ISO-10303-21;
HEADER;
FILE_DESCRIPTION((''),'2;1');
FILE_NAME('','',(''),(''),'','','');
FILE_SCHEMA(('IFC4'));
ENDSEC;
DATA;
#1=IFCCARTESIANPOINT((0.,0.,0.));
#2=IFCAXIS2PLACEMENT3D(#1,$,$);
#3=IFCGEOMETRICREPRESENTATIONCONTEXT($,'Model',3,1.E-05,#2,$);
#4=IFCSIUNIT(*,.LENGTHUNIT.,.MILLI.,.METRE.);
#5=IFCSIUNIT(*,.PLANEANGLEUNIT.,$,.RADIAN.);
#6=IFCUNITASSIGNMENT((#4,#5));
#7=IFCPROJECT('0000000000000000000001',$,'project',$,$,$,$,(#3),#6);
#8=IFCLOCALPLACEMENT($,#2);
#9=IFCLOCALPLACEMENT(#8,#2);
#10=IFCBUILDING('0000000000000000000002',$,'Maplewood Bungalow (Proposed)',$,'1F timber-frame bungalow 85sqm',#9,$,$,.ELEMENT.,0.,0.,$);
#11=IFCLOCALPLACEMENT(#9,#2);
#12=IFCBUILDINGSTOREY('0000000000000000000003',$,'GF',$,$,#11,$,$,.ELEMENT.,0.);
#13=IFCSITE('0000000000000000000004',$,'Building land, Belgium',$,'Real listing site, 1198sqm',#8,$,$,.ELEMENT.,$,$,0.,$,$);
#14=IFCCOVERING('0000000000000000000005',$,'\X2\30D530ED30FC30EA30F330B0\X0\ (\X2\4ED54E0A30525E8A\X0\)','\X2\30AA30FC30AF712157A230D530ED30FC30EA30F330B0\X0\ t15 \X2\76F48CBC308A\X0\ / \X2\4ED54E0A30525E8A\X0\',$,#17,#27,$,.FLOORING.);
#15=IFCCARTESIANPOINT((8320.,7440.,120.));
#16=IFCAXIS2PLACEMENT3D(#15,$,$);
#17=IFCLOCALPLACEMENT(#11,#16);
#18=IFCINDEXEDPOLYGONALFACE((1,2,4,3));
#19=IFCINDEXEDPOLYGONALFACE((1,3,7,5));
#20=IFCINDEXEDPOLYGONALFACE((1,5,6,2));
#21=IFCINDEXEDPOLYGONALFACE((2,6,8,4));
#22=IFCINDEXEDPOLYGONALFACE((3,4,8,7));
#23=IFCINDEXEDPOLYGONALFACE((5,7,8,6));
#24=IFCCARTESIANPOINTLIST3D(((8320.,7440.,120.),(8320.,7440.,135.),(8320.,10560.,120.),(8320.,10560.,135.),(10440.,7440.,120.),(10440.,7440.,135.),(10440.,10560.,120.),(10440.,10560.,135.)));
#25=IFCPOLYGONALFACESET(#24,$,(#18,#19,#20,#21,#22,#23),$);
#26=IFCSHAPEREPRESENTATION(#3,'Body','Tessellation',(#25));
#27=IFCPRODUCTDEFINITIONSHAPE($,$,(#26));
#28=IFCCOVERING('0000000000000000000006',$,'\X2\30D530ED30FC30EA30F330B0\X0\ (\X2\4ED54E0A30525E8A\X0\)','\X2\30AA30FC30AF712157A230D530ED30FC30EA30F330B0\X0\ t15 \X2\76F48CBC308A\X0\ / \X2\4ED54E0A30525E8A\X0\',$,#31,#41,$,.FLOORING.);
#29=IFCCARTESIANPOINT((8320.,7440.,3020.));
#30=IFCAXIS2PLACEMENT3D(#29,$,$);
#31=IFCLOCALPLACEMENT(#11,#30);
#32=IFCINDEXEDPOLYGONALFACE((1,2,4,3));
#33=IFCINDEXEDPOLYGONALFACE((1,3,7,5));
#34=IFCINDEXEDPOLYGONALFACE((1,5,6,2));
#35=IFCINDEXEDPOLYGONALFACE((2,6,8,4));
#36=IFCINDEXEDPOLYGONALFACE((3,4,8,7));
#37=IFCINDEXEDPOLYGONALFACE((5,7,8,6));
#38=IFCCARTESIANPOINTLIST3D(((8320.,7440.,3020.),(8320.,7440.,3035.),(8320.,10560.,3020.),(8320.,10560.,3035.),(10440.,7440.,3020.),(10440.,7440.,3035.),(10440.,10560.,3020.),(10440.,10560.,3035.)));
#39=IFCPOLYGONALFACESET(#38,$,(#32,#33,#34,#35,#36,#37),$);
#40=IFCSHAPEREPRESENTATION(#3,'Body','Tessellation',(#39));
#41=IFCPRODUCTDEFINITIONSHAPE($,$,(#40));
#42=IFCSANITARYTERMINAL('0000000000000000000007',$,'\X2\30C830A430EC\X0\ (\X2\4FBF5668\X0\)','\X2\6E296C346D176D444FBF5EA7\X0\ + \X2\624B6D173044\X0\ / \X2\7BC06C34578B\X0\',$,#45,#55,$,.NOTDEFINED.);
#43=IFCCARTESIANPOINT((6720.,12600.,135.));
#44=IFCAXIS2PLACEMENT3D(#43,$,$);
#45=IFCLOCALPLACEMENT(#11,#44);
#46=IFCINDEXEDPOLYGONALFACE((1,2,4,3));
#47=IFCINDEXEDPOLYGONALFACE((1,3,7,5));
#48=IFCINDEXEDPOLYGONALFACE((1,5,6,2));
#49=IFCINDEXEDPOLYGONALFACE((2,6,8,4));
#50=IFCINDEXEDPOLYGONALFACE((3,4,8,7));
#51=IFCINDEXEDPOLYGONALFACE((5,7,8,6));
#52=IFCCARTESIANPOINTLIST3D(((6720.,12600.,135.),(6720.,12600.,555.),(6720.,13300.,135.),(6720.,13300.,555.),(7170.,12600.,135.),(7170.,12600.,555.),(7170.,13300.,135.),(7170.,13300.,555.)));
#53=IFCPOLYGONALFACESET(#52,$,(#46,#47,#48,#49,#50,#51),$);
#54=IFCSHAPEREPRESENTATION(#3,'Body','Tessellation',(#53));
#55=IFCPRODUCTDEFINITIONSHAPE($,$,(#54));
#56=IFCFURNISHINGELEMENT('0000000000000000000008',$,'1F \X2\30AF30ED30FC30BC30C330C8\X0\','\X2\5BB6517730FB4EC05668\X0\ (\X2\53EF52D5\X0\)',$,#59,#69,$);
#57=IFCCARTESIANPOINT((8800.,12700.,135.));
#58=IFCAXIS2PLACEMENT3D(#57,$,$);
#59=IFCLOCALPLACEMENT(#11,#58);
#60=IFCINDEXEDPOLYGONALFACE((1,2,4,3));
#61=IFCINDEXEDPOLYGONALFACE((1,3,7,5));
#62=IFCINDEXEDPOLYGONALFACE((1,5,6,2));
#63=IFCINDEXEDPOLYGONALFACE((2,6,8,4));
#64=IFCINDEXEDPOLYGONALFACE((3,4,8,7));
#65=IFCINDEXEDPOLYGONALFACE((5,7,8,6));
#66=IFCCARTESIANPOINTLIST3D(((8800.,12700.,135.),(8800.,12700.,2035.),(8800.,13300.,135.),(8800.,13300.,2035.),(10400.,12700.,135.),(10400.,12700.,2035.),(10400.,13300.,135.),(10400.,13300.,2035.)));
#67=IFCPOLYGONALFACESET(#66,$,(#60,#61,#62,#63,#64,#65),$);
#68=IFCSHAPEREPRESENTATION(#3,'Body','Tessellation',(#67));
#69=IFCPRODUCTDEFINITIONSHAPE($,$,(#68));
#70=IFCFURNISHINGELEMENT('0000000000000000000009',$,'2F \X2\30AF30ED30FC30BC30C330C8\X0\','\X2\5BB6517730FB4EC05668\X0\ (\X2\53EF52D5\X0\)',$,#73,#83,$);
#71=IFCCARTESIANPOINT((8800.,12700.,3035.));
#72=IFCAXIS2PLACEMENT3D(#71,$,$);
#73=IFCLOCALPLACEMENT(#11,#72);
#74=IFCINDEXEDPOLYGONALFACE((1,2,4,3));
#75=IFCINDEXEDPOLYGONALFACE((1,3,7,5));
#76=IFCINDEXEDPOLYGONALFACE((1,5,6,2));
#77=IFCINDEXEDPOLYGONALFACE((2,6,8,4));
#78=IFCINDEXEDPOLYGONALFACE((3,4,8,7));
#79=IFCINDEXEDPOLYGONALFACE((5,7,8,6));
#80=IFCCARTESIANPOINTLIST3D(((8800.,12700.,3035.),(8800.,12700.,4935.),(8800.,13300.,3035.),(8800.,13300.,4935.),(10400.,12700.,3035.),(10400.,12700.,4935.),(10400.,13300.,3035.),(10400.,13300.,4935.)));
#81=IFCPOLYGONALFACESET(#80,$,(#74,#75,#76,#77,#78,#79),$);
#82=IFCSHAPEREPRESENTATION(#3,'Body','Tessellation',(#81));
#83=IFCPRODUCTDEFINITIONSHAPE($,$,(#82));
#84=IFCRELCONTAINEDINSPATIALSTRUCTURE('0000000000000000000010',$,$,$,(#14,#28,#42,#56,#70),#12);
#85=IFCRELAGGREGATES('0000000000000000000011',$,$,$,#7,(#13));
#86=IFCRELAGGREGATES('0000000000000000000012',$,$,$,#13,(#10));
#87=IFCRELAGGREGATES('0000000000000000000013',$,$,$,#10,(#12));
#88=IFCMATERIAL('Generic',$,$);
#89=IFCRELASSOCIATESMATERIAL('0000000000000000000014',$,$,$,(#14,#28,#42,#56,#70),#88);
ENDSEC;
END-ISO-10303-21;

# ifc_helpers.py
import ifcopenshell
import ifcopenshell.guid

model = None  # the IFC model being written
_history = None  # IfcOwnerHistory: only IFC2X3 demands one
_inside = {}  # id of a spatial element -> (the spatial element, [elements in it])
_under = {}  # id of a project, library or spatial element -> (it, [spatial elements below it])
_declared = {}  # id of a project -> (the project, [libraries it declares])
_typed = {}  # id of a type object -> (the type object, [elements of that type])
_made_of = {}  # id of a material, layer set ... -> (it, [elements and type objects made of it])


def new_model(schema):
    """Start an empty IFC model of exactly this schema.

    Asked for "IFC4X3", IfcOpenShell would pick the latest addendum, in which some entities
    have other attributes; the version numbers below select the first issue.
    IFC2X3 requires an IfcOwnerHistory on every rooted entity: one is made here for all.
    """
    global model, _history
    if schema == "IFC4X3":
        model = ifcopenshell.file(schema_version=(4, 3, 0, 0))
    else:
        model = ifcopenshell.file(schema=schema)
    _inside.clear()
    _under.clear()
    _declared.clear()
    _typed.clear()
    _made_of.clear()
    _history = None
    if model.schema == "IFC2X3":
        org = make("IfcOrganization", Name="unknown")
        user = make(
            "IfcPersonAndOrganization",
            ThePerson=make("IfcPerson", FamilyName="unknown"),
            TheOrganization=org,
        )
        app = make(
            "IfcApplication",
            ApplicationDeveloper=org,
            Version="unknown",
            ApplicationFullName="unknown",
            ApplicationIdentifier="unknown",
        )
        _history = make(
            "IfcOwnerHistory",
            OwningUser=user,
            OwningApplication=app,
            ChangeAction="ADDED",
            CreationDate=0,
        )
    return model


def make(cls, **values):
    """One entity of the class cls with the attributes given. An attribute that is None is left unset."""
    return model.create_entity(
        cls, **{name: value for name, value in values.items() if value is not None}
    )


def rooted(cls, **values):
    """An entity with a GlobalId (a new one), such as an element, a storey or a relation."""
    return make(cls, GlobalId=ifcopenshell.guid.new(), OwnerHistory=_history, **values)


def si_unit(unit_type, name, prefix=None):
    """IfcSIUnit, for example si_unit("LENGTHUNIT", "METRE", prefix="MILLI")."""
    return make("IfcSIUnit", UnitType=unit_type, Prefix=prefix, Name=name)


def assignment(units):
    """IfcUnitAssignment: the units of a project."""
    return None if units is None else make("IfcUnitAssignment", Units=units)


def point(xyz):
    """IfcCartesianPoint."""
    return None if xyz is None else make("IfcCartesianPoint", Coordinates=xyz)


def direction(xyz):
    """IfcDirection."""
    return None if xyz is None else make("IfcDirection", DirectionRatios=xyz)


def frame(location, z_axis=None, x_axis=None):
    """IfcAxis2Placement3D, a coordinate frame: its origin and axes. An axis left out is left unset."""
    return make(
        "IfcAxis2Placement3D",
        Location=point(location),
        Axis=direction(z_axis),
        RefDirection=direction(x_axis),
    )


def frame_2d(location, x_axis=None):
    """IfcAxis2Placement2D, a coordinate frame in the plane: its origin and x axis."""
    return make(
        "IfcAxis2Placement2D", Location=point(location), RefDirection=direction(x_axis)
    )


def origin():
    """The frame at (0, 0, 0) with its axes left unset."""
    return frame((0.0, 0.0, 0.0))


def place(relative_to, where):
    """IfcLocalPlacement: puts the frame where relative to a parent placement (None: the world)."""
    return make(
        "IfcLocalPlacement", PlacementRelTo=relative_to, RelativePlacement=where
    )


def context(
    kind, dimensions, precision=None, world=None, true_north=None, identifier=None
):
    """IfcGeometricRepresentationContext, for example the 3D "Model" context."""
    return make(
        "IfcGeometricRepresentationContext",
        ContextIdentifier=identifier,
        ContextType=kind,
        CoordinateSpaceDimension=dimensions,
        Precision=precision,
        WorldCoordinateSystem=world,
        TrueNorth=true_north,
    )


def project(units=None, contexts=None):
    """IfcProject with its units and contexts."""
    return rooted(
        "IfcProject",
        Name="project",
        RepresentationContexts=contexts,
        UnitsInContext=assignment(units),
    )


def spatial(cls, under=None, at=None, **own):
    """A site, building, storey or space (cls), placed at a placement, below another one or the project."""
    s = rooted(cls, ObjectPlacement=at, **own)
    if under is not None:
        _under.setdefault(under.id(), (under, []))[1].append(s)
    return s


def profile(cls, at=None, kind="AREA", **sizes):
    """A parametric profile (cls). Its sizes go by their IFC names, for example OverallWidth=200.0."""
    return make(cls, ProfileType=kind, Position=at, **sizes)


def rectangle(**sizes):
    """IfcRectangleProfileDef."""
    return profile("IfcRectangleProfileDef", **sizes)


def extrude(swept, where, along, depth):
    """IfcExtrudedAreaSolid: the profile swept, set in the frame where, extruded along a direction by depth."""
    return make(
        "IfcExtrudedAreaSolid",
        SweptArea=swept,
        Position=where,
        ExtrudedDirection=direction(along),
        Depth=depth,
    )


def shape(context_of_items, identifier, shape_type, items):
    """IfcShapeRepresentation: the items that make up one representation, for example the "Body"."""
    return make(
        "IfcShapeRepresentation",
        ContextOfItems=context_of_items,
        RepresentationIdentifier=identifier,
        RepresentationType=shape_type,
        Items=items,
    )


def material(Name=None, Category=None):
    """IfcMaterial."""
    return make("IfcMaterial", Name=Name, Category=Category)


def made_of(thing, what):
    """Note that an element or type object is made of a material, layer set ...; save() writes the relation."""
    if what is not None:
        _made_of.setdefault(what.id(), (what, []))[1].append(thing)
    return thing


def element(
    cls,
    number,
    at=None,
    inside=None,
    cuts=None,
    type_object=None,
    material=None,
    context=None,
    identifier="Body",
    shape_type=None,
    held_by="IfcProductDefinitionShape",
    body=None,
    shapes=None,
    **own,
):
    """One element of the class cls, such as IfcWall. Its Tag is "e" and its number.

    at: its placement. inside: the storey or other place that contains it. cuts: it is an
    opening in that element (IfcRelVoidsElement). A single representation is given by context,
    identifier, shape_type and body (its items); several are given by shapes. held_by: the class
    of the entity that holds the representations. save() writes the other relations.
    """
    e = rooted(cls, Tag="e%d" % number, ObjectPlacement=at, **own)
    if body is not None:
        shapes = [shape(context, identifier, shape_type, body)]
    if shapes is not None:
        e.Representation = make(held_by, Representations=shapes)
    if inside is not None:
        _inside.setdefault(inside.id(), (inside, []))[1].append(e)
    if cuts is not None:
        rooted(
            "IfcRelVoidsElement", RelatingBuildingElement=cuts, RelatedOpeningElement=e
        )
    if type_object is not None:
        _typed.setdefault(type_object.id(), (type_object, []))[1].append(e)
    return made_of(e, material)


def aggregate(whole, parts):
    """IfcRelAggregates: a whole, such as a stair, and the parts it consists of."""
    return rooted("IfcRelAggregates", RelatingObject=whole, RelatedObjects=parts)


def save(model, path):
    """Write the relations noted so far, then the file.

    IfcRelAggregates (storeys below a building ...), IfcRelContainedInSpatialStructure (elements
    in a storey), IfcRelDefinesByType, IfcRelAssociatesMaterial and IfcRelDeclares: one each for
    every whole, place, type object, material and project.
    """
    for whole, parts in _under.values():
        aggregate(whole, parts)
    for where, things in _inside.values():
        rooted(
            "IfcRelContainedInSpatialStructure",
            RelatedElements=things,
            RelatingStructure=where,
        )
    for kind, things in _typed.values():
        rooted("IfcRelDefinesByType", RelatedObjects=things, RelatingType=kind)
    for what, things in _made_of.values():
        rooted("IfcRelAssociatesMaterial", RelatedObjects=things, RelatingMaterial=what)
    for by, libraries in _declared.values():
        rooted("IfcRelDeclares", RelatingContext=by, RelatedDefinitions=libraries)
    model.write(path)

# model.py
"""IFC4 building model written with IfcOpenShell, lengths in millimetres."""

from ifc_helpers import new_model, si_unit, frame, frame_2d, origin, place, context, project, spatial, rectangle, extrude, material, element, save


model = new_model("IFC4")

# Units and contexts
model_context = context("Model", 3, precision=1e-05, world=origin())
ifc_project = project(units=[si_unit("LENGTHUNIT", "METRE", prefix="MILLI"), si_unit("PLANEANGLEUNIT", "RADIAN")], contexts=[model_context])

# Site, building, storey
site_placement = place(None, origin())
site = spatial("IfcSite", under=ifc_project, at=site_placement, Name="Building land, Belgium", ObjectType="Real listing site, 1198sqm", CompositionType="ELEMENT", RefElevation=0.0)
building_placement = place(site_placement, origin())
building = spatial("IfcBuilding", under=site, at=building_placement, Name="Maplewood Bungalow (Proposed)", ObjectType="1F timber-frame bungalow 85sqm", CompositionType="ELEMENT", ElevationOfRefHeight=0.0, ElevationOfTerrain=0.0)
storey_placement = place(building_placement, origin())
storey = spatial("IfcBuildingStorey", under=building, at=storey_placement, Name="GF", CompositionType="ELEMENT", Elevation=0.0)

# Shared definitions
ifc_material_1 = material(Name="Generic")

# Coverings
covering_1_placement = place(storey_placement, frame((8320.0, 7440.0, 120.0)))
element("IfcCovering", 1, at=covering_1_placement, inside=storey, material=ifc_material_1, Name="フローリング (仕上げ床)", Description="オーク無垢フローリング t15 直貼り / 仕上げ床", PredefinedType="FLOORING", context=model_context, shape_type="SweptSolid", body=[
    extrude(rectangle(XDim=2120.0, YDim=3120.0, at=frame_2d((1060.0, 1560.0))), frame((8320.0, 7440.0, 120.0)), (0.0, 0.0, 1.0), 15.0),
])
covering_2_placement = place(storey_placement, frame((8320.0, 7440.0, 3020.0)))
element("IfcCovering", 2, at=covering_2_placement, inside=storey, material=ifc_material_1, Name="フローリング (仕上げ床)", Description="オーク無垢フローリング t15 直貼り / 仕上げ床", PredefinedType="FLOORING", context=model_context, shape_type="SweptSolid", body=[
    extrude(rectangle(XDim=2120.0, YDim=3120.0, at=frame_2d((1060.0, 1560.0))), frame((8320.0, 7440.0, 3020.0)), (0.0, 0.0, 1.0), 15.0),
])

# Sanitary terminal
sanitary_terminal_placement = place(storey_placement, frame((6720.0, 12600.0, 135.0)))
element("IfcSanitaryTerminal", 3, at=sanitary_terminal_placement, inside=storey, material=ifc_material_1, Name="トイレ (便器)", Description="温水洗浄便座 + 手洗い / 節水型", PredefinedType="NOTDEFINED", context=model_context, shape_type="SweptSolid", body=[
    extrude(rectangle(XDim=450.0, YDim=700.0, at=frame_2d((225.0, 350.0))), frame((6720.0, 12600.0, 135.0)), (0.0, 0.0, 1.0), 420.0),
])

# Furnishing elements
furnishing_1_placement = place(storey_placement, frame((8800.0, 12700.0, 135.0)))
element("IfcFurnishingElement", 4, at=furnishing_1_placement, inside=storey, material=ifc_material_1, Name="1F クローゼット", Description="家具・什器 (可動)", context=model_context, shape_type="SweptSolid", body=[
    extrude(rectangle(XDim=1600.0, YDim=600.0, at=frame_2d((800.0, 300.0))), frame((8800.0, 12700.0, 135.0)), (0.0, 0.0, 1.0), 1900.0),
])
furnishing_2_placement = place(storey_placement, frame((8800.0, 12700.0, 3035.0)))
element("IfcFurnishingElement", 5, at=furnishing_2_placement, inside=storey, material=ifc_material_1, Name="2F クローゼット", Description="家具・什器 (可動)", context=model_context, shape_type="SweptSolid", body=[
    extrude(rectangle(XDim=1600.0, YDim=600.0, at=frame_2d((800.0, 300.0))), frame((8800.0, 12700.0, 3035.0)), (0.0, 0.0, 1.0), 1900.0),
])

save(model, "model.ifc")
